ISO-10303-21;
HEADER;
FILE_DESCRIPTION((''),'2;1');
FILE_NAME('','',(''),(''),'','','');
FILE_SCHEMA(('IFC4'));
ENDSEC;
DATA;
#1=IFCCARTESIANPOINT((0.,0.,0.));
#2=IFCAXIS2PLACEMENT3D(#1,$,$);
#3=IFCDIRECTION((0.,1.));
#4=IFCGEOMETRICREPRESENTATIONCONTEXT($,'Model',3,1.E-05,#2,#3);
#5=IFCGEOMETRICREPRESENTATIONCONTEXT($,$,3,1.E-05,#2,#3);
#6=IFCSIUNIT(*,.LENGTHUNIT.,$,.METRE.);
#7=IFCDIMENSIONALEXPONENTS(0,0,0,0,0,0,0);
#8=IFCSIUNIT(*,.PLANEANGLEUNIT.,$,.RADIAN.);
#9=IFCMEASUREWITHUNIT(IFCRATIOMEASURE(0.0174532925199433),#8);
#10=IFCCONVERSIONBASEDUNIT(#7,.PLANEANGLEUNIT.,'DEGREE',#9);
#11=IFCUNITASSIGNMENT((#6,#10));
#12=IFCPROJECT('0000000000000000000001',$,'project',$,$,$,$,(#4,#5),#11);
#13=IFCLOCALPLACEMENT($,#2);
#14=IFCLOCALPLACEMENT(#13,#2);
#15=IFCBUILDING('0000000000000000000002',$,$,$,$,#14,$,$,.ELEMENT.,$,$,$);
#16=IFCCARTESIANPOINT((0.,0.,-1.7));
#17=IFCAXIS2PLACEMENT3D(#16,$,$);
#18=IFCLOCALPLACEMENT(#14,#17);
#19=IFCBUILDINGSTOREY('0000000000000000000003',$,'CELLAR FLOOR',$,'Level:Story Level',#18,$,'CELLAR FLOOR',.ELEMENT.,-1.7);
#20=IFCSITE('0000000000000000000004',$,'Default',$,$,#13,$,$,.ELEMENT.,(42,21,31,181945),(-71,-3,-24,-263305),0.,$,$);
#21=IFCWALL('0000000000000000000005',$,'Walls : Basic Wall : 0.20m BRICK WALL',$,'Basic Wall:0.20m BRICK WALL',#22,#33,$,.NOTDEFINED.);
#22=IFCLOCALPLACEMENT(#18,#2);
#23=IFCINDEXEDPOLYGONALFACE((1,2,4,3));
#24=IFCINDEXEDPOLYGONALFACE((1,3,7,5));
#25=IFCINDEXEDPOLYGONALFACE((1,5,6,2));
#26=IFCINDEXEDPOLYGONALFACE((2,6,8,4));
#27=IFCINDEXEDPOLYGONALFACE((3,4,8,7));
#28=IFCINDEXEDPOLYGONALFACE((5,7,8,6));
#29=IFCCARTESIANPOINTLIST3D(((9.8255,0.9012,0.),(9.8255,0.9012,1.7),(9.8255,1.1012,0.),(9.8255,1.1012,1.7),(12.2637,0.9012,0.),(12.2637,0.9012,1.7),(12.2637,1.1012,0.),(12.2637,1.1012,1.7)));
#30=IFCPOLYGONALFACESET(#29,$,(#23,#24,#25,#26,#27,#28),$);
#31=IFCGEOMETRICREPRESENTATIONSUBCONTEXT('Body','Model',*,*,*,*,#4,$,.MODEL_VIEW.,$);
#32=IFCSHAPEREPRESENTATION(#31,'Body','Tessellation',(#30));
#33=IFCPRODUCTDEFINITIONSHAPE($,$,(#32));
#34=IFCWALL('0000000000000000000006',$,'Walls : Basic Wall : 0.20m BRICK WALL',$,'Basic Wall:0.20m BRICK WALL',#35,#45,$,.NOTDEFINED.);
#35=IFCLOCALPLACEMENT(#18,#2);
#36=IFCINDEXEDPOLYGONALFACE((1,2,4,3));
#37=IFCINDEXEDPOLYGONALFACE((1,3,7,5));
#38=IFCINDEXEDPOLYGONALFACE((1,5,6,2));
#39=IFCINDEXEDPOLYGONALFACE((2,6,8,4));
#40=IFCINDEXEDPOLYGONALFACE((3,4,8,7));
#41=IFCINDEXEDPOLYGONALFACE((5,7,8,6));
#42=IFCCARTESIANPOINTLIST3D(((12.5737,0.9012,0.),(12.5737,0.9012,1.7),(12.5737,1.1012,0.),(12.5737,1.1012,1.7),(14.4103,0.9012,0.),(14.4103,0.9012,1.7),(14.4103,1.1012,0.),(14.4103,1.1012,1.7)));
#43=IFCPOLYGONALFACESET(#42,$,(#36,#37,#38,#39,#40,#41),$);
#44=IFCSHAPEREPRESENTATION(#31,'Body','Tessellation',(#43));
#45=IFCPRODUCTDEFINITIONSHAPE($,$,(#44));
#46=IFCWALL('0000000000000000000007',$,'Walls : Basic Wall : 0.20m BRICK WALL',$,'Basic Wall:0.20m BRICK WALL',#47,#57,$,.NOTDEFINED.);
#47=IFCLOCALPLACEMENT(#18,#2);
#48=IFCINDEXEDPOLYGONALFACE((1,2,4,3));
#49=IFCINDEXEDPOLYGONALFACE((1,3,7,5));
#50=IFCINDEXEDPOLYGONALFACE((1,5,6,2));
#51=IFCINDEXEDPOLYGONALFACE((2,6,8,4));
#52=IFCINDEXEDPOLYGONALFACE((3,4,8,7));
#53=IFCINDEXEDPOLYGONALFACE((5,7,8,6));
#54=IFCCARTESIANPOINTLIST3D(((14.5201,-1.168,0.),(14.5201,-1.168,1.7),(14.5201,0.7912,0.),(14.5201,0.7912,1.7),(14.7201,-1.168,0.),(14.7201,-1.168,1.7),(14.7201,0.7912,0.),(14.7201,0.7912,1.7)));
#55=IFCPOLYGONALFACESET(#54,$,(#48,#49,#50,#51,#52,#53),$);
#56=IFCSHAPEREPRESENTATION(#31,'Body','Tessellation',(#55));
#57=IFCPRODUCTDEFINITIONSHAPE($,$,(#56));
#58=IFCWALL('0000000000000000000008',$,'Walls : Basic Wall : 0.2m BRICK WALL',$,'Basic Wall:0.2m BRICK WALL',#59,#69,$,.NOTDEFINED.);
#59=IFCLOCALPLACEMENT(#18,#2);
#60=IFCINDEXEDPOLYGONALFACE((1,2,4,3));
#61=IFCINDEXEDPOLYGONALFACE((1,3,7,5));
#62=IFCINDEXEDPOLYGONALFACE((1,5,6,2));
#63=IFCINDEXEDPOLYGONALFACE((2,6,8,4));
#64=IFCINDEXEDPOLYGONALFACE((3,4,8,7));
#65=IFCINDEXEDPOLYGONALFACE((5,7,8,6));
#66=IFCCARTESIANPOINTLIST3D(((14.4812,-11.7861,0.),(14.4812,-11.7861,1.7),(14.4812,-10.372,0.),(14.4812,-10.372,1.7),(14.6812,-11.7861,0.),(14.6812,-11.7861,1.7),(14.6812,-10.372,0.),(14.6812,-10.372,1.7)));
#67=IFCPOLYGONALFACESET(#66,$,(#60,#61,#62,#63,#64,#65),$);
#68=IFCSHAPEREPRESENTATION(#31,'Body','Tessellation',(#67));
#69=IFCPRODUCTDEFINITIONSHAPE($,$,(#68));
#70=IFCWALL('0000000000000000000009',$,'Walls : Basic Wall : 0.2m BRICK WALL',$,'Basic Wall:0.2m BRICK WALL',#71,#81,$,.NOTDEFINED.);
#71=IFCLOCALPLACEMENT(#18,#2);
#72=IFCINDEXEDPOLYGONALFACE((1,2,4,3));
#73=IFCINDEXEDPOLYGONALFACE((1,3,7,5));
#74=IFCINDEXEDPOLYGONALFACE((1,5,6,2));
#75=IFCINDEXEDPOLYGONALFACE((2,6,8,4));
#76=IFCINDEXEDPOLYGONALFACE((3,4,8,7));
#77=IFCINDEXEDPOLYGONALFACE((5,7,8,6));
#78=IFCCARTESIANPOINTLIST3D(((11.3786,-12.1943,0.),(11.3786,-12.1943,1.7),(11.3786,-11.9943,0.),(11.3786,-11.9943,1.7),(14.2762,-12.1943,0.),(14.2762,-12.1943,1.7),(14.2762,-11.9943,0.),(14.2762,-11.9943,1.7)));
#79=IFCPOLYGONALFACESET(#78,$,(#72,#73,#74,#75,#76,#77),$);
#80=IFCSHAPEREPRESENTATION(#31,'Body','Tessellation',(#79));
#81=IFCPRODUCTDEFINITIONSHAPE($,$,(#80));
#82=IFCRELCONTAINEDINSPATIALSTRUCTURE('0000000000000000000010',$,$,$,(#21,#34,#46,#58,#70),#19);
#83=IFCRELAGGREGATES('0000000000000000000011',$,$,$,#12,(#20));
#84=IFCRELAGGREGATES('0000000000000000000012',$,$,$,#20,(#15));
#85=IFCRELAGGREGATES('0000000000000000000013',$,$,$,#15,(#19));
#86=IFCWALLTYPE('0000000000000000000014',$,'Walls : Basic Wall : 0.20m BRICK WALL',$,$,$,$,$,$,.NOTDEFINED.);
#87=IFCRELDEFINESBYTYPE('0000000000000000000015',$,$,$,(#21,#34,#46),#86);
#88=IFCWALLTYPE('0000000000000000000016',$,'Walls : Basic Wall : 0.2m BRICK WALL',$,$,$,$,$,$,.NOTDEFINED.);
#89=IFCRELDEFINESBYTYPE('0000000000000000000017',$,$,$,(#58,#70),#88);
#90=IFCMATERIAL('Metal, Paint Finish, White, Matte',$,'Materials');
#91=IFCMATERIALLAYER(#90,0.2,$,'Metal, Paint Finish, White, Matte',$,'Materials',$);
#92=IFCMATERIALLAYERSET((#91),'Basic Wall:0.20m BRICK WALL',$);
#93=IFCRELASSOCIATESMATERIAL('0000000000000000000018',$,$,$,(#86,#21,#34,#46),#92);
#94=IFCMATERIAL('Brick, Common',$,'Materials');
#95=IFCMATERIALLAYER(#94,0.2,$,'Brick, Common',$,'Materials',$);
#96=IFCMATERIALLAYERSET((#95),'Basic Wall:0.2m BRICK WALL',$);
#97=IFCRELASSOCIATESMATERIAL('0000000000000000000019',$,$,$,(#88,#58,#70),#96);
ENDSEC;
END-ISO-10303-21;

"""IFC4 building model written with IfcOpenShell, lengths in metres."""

from ifc_helpers import new_model, entity, si_unit, converted_unit, direction, frame, frame_2d, origin, place, context, subcontext, project, spatial, rectangle, extrude, material, layer, layer_set, layer_usage, type_object, element, save


model = new_model("IFC4")

# Units and contexts
model_context = context("Model", 3, precision=1e-05, world=origin(), true_north=direction((0.0, 1.0)))
context_of_model = context(None, 3, precision=1e-05, world=origin(), true_north=direction((0.0, 1.0)))
body_context = subcontext(model_context, "Body", "Model", "MODEL_VIEW")
ifc_project = project(units=[si_unit("LENGTHUNIT", "METRE"), converted_unit("PLANEANGLEUNIT", "DEGREE", entity("IfcRatioMeasure", 0.0174532925199433), si_unit("PLANEANGLEUNIT", "RADIAN"), dimensions=[0, 0, 0, 0, 0, 0, 0])], contexts=[model_context, context_of_model])

# Site, building, storey
site_placement = place(None, origin())
site = spatial("IfcSite", under=ifc_project, at=site_placement, Name="Default", CompositionType="ELEMENT", RefLatitude=(42, 21, 31, 181945), RefLongitude=(-71, -3, -24, -263305), RefElevation=0.0)
building_placement = place(site_placement, origin())
building = spatial("IfcBuilding", under=site, at=building_placement, CompositionType="ELEMENT")
storey_placement = place(building_placement, frame((0.0, 0.0, -1.7)))
storey = spatial("IfcBuildingStorey", under=building, at=storey_placement, Name="CELLAR FLOOR", ObjectType="Level:Story Level", LongName="CELLAR FLOOR", CompositionType="ELEMENT", Elevation=-1.7)

# Shared definitions
ifc_material_1 = material(Name="Metal, Paint Finish, White, Matte", Category="Materials")

# Shared definitions
ifc_material_2 = material(Name="Brick, Common", Category="Materials")

# Walls
ifc_layer_1 = layer(ifc_material_1, 0.2, Name="Metal, Paint Finish, White, Matte", Category="Materials")
ifc_layer_set_1 = layer_set([ifc_layer_1], Name="Basic Wall:0.20m BRICK WALL")
ifc_layer_usage_1 = layer_usage(ifc_layer_set_1, "AXIS2", "NEGATIVE", 0.1)
wall_type_1 = type_object("IfcWallType", Name="Walls : Basic Wall : 0.20m BRICK WALL", PredefinedType="NOTDEFINED", material=ifc_layer_set_1)
wall_1_placement = place(storey_placement, frame((12.2637, 1.0012, 0.0), z_axis=(0.0, 0.0, 1.0), x_axis=(-1.0, 0.0, 0.0)))
element("IfcWall", 1, at=wall_1_placement, inside=storey, type_object=wall_type_1, material=ifc_layer_usage_1, Name="Walls : Basic Wall : 0.20m BRICK WALL", ObjectType="Basic Wall:0.20m BRICK WALL", PredefinedType="NOTDEFINED", context=body_context, shape_type="SweptSolid", body=[
    extrude(rectangle(XDim=2.4382, YDim=0.2, at=frame_2d((1.2191, 0.0), x_axis=(-1.0, 0.0))), origin(), (0.0, 0.0, 1.0), 1.7),
])
ifc_layer_usage_2 = layer_usage(ifc_layer_set_1, "AXIS2", "NEGATIVE", 0.1)
wall_2_placement = place(storey_placement, frame((14.4103, 1.0012, 0.0), z_axis=(0.0, 0.0, 1.0), x_axis=(-1.0, 0.0, 0.0)))
element("IfcWall", 2, at=wall_2_placement, inside=storey, type_object=wall_type_1, material=ifc_layer_usage_2, Name="Walls : Basic Wall : 0.20m BRICK WALL", ObjectType="Basic Wall:0.20m BRICK WALL", PredefinedType="NOTDEFINED", context=body_context, shape_type="SweptSolid", body=[
    extrude(rectangle(XDim=1.8366, YDim=0.2, at=frame_2d((0.9183, 0.0), x_axis=(-1.0, 0.0))), origin(), (0.0, 0.0, 1.0), 1.7),
])
ifc_layer_usage_3 = layer_usage(ifc_layer_set_1, "AXIS2", "NEGATIVE", 0.1)
wall_3_placement = place(storey_placement, frame((14.6201, -1.168, 0.0), z_axis=(0.0, 0.0, 1.0), x_axis=(0.0, 1.0, 0.0)))
element("IfcWall", 3, at=wall_3_placement, inside=storey, type_object=wall_type_1, material=ifc_layer_usage_3, Name="Walls : Basic Wall : 0.20m BRICK WALL", ObjectType="Basic Wall:0.20m BRICK WALL", PredefinedType="NOTDEFINED", context=body_context, shape_type="SweptSolid", body=[
    extrude(rectangle(XDim=1.9592, YDim=0.2, at=frame_2d((0.9796, 0.0), x_axis=(-1.0, 0.0))), origin(), (0.0, 0.0, 1.0), 1.7),
])
ifc_layer_2 = layer(ifc_material_2, 0.2, Name="Brick, Common", Category="Materials")
ifc_layer_set_2 = layer_set([ifc_layer_2], Name="Basic Wall:0.2m BRICK WALL")
ifc_layer_usage_4 = layer_usage(ifc_layer_set_2, "AXIS2", "NEGATIVE", 0.1)
wall_type_2 = type_object("IfcWallType", Name="Walls : Basic Wall : 0.2m BRICK WALL", PredefinedType="NOTDEFINED", material=ifc_layer_set_2)
wall_4_placement = place(storey_placement, frame((14.5812, -11.7861, 0.0), z_axis=(0.0, 0.0, 1.0), x_axis=(0.0, 1.0, 0.0)))
element("IfcWall", 4, at=wall_4_placement, inside=storey, type_object=wall_type_2, material=ifc_layer_usage_4, Name="Walls : Basic Wall : 0.2m BRICK WALL", ObjectType="Basic Wall:0.2m BRICK WALL", PredefinedType="NOTDEFINED", context=body_context, shape_type="SweptSolid", body=[
    extrude(rectangle(XDim=1.4141, YDim=0.2, at=frame_2d((0.7071, 0.0), x_axis=(-1.0, 0.0))), origin(), (0.0, 0.0, 1.0), 1.7),
])
ifc_layer_usage_5 = layer_usage(ifc_layer_set_2, "AXIS2", "NEGATIVE", 0.1)
wall_5_placement = place(storey_placement, frame((11.3786, -12.0943, 0.0)))
element("IfcWall", 5, at=wall_5_placement, inside=storey, type_object=wall_type_2, material=ifc_layer_usage_5, Name="Walls : Basic Wall : 0.2m BRICK WALL", ObjectType="Basic Wall:0.2m BRICK WALL", PredefinedType="NOTDEFINED", context=body_context, shape_type="SweptSolid", body=[
    extrude(rectangle(XDim=2.8976, YDim=0.2, at=frame_2d((1.4488, 0.0), x_axis=(-1.0, 0.0))), origin(), (0.0, 0.0, 1.0), 1.7),
])

save(model, "model.ifc")
